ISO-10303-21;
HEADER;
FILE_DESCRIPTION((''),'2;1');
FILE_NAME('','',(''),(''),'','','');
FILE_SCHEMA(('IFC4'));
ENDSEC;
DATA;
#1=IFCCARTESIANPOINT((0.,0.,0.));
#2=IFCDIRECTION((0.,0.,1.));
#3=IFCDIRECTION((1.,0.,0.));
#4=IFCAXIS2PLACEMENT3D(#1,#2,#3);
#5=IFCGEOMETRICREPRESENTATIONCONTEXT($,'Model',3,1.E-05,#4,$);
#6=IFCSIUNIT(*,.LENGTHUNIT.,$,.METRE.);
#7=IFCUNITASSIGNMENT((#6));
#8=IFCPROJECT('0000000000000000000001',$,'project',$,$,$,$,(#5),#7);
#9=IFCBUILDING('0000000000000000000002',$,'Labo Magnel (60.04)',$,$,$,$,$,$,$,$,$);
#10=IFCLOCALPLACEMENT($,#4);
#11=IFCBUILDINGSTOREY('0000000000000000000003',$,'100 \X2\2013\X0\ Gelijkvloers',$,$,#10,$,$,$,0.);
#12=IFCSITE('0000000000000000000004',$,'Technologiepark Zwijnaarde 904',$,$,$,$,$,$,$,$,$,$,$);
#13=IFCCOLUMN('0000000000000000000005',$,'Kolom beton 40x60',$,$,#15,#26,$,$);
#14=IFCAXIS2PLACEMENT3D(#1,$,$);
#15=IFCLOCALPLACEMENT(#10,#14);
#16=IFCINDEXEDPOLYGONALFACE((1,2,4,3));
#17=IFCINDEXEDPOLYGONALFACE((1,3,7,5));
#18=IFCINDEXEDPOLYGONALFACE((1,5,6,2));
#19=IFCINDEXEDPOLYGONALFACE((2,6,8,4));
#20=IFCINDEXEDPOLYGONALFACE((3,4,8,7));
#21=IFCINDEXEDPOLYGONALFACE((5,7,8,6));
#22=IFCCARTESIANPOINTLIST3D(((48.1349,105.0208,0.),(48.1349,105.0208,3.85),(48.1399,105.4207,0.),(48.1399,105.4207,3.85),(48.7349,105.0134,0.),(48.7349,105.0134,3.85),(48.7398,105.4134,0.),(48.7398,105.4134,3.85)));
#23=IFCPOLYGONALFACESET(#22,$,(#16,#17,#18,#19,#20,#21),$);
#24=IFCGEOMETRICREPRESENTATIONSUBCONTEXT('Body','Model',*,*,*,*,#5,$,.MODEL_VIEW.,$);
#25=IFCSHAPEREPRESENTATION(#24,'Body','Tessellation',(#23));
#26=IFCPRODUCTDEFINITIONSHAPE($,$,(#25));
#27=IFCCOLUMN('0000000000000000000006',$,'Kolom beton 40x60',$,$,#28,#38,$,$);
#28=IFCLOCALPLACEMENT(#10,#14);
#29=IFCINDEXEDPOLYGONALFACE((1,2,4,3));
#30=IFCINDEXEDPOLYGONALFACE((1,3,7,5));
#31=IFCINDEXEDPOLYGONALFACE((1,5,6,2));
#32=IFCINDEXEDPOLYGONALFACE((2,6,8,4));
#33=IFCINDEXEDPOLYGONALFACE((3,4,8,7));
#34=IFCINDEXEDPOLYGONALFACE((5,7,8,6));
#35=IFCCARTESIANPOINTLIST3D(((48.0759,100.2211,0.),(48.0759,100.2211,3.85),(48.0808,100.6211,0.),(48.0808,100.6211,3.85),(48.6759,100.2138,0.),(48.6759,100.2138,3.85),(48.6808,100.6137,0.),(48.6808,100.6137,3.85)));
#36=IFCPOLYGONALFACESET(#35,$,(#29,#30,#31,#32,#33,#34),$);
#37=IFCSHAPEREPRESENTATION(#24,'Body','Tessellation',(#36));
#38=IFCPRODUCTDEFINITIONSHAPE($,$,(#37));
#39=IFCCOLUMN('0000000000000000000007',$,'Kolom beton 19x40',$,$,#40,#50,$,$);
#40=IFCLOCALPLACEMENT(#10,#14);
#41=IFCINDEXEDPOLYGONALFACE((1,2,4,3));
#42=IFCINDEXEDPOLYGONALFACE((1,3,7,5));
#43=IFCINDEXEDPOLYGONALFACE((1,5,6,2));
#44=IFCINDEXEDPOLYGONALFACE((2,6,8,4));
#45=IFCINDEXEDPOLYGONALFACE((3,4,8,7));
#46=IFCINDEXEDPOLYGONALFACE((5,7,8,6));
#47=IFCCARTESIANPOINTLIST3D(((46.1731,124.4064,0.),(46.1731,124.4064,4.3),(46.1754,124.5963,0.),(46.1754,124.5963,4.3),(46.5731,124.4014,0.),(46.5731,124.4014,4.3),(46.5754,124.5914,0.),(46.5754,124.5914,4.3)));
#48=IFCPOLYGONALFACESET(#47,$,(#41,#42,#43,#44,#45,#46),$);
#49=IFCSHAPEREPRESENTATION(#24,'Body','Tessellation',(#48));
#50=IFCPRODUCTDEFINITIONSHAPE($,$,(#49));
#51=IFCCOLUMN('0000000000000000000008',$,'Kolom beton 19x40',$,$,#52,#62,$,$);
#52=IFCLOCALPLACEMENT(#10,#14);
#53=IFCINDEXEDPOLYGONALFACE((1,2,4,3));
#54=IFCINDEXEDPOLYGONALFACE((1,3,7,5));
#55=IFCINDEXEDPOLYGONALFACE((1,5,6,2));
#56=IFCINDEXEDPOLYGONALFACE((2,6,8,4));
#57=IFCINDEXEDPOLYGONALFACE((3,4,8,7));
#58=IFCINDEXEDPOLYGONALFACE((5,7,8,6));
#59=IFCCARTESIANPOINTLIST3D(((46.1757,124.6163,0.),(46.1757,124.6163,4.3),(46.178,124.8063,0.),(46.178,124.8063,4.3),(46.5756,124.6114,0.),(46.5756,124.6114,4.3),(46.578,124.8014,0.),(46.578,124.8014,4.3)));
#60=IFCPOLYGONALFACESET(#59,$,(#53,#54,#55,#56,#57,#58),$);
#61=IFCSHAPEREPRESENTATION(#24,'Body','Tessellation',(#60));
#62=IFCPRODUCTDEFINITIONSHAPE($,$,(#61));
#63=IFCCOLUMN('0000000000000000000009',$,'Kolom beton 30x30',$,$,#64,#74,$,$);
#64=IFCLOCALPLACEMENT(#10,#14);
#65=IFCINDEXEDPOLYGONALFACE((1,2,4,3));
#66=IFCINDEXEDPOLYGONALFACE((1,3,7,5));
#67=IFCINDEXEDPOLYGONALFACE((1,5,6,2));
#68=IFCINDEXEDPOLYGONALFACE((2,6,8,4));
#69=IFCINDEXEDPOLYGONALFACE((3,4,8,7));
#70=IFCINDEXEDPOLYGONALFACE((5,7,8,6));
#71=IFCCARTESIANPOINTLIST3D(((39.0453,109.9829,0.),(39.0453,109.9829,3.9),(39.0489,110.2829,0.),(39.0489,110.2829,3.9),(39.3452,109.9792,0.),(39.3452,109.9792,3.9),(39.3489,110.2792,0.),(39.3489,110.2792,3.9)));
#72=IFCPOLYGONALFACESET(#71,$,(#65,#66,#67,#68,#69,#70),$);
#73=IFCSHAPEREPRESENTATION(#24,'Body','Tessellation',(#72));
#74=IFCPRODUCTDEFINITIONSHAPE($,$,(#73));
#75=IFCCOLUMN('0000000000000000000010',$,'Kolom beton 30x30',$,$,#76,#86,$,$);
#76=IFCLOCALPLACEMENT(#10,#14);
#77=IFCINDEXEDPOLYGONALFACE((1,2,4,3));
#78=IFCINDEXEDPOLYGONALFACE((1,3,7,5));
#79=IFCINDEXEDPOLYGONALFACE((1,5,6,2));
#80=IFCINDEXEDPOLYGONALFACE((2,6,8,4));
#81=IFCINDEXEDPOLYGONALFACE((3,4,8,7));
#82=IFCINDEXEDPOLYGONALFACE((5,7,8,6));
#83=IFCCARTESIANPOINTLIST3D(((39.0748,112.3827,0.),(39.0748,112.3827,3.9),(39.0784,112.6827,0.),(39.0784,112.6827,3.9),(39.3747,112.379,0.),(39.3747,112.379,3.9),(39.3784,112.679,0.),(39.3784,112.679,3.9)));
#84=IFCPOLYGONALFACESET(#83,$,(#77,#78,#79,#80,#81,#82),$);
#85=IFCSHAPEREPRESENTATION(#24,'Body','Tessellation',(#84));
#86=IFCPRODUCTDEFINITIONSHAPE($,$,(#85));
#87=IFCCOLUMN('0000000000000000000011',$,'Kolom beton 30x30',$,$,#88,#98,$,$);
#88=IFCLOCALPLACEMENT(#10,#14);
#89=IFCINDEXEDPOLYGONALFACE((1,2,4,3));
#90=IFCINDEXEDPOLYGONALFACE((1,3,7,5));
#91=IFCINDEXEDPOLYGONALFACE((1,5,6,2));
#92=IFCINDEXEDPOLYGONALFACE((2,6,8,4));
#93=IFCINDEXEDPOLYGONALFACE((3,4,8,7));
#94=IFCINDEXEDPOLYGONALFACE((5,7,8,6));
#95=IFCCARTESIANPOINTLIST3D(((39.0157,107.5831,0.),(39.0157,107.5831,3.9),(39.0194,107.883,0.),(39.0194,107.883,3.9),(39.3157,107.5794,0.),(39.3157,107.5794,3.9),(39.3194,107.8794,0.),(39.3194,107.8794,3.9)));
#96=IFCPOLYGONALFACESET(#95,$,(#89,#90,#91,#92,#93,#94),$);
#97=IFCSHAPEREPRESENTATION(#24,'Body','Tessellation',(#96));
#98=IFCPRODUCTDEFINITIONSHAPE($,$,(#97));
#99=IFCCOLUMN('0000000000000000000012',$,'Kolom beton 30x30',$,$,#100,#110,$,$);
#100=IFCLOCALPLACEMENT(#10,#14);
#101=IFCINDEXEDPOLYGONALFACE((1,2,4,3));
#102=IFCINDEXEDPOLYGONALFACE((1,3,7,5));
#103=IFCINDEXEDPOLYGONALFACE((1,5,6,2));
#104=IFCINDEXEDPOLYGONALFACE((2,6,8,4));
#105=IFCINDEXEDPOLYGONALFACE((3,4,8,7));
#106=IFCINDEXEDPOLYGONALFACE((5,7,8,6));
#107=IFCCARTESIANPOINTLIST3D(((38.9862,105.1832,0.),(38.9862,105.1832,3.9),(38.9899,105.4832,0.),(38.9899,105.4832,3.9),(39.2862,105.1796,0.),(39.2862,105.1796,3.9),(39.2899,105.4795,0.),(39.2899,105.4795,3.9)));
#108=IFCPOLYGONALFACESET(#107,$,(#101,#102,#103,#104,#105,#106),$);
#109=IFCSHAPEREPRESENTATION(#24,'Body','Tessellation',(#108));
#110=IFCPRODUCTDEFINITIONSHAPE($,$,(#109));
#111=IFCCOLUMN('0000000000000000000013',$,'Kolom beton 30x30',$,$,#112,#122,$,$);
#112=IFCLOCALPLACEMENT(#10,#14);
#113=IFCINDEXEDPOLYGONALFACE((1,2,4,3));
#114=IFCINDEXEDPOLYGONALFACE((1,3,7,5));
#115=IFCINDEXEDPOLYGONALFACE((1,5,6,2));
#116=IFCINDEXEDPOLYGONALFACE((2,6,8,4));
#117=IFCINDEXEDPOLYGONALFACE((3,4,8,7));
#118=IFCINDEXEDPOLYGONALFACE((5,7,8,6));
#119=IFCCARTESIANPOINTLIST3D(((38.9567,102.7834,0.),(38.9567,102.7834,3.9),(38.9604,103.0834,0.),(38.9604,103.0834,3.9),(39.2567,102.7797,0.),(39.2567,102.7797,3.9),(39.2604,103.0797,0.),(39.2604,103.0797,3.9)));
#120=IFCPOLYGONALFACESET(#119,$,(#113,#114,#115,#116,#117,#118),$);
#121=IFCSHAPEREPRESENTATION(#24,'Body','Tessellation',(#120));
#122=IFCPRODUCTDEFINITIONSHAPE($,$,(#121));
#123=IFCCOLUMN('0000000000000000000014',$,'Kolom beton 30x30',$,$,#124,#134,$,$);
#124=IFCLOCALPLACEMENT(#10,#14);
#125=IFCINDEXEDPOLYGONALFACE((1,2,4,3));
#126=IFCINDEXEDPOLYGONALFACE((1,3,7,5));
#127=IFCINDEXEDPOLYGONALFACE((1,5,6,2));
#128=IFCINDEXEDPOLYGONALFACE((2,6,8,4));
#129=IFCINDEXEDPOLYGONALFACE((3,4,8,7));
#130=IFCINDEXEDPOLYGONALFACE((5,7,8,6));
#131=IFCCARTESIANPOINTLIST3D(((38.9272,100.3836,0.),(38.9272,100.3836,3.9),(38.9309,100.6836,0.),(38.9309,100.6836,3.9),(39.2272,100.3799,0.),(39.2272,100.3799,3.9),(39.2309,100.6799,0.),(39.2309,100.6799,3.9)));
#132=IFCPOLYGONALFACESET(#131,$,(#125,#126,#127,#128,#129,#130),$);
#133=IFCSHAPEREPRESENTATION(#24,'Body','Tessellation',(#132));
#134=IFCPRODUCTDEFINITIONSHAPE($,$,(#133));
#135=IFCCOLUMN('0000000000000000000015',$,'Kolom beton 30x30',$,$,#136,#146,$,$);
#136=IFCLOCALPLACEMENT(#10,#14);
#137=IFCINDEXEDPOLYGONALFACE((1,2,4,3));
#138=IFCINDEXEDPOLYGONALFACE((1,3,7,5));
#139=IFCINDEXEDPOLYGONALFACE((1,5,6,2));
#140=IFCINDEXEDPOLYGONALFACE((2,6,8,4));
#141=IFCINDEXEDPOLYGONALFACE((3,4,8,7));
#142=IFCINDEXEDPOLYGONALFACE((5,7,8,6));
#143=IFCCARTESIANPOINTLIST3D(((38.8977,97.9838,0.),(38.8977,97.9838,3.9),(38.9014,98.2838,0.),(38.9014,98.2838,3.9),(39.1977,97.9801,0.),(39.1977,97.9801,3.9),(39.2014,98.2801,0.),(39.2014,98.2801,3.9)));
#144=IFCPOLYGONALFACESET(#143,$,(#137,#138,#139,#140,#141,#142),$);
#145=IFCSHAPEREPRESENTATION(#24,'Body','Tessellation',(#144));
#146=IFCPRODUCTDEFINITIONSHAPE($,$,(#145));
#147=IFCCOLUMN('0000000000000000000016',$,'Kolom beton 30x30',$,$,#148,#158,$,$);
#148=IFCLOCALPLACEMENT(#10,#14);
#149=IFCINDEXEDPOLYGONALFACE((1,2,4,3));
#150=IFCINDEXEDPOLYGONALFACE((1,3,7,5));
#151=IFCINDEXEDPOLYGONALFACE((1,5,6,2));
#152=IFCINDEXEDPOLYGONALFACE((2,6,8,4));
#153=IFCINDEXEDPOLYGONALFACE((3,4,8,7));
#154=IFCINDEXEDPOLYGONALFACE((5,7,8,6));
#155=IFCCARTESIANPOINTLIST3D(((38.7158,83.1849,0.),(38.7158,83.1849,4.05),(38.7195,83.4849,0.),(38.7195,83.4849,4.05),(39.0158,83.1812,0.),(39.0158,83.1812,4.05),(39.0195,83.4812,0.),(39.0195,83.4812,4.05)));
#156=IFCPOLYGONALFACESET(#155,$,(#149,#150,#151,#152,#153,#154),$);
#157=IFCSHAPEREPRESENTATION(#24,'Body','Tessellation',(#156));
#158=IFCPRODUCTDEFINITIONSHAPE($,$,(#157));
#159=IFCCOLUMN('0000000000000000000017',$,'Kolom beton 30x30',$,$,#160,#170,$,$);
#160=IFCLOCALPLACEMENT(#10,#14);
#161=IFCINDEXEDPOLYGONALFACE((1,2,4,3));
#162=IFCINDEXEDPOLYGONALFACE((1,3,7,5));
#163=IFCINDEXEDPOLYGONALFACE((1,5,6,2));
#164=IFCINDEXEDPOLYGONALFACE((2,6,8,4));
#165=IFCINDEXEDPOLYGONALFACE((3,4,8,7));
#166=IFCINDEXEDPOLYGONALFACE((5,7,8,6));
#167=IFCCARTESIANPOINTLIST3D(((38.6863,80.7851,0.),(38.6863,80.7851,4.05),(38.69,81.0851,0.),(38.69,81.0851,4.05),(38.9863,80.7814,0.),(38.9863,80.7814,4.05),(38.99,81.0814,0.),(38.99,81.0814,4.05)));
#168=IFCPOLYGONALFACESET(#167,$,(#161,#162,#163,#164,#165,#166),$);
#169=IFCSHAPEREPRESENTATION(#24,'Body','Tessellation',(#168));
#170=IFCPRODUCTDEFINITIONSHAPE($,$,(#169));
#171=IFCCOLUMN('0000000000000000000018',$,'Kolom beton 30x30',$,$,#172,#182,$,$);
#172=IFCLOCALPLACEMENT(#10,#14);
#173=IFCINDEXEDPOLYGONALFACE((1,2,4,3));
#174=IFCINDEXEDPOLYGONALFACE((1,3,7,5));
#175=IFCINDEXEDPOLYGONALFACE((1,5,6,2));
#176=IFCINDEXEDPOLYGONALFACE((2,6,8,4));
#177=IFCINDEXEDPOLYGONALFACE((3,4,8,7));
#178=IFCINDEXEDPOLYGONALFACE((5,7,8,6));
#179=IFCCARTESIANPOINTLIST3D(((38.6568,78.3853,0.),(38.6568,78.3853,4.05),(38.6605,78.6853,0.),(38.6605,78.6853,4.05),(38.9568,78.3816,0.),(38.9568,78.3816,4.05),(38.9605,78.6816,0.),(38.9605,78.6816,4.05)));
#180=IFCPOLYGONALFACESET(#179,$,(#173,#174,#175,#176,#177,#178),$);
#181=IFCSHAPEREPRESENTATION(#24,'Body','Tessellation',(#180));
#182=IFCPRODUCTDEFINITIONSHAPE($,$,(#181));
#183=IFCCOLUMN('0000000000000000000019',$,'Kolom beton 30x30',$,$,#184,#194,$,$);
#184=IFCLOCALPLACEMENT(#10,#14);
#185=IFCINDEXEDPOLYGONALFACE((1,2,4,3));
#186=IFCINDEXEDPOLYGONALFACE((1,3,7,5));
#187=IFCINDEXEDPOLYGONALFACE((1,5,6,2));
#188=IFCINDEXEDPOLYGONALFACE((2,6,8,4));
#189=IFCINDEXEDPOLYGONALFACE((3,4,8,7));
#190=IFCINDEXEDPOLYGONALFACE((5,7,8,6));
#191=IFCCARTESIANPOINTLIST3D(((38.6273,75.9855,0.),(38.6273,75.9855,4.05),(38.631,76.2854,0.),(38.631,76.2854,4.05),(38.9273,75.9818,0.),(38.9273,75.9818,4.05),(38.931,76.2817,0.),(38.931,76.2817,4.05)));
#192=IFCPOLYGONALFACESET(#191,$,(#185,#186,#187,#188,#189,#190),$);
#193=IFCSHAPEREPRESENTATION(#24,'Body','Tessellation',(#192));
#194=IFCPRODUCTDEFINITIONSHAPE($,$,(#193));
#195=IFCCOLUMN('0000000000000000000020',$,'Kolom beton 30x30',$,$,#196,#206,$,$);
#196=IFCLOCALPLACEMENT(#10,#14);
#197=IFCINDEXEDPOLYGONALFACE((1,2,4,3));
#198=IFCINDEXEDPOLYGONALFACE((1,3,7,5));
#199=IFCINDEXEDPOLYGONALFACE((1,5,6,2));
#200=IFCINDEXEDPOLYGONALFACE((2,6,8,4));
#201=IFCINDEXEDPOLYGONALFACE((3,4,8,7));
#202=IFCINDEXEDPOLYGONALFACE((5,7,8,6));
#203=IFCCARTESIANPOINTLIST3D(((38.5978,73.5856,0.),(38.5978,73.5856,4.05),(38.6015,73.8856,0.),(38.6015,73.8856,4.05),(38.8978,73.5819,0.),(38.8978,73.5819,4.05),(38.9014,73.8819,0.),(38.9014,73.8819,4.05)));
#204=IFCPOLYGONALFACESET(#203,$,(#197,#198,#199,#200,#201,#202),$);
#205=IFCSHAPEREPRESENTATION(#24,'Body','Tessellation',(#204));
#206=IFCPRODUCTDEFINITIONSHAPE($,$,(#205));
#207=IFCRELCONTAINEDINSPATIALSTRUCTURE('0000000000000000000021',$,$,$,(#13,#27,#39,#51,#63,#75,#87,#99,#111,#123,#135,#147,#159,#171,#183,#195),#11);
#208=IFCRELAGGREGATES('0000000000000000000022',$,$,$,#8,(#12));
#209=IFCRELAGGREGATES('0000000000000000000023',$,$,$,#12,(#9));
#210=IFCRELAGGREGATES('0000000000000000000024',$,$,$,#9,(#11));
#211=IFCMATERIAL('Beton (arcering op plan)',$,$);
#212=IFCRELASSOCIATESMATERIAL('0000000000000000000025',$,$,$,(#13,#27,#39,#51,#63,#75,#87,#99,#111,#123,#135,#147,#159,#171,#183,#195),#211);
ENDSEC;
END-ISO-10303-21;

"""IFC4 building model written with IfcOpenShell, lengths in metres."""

from ifc_helpers import new_model, si_unit, origin, origin_with_axes, place, context, subcontext, project, spatial, polyline, outline, extrude, material, element, save


model = new_model("IFC4")

# Units and contexts
model_context = context("Model", 3, precision=1e-05, world=origin_with_axes())
body_context = subcontext(model_context, "Body", "Model", "MODEL_VIEW")
ifc_project = project(units=[si_unit("LENGTHUNIT", "METRE")], contexts=[model_context])

# Site, building, storey
site = spatial("IfcSite", under=ifc_project, Name="Technologiepark Zwijnaarde 904")
building = spatial("IfcBuilding", under=site, Name="Labo Magnel (60.04)")
storey_placement = place(None, origin_with_axes())
storey = spatial("IfcBuildingStorey", under=building, at=storey_placement, Name="100 – Gelijkvloers", Elevation=0.0)

# Columns
ifc_material = material(Name="Beton (arcering op plan)")
column_1_placement = place(storey_placement, origin_with_axes())
element("IfcColumn", 1, at=column_1_placement, inside=storey, material=ifc_material, Name="Kolom beton 40x60", context=body_context, shape_type="SweptSolid", body=[
    extrude(outline(polyline([(48.7398, 105.4134), (48.1399, 105.4207), (48.1349, 105.0208), (48.7349, 105.0134), (48.7398, 105.4134)])), origin(), (0.0, 0.0, 1.0), 3.85),
])
column_2_placement = place(storey_placement, origin_with_axes())
element("IfcColumn", 2, at=column_2_placement, inside=storey, material=ifc_material, Name="Kolom beton 40x60", context=body_context, shape_type="SweptSolid", body=[
    extrude(outline(polyline([(48.6808, 100.6137), (48.0808, 100.6211), (48.0759, 100.2211), (48.6759, 100.2138), (48.6808, 100.6137)])), origin(), (0.0, 0.0, 1.0), 3.85),
])
column_3_placement = place(storey_placement, origin_with_axes())
element("IfcColumn", 3, at=column_3_placement, inside=storey, material=ifc_material, Name="Kolom beton 19x40", context=body_context, shape_type="SweptSolid", body=[
    extrude(outline(polyline([(46.5754, 124.5914), (46.1754, 124.5963), (46.1731, 124.4064), (46.5731, 124.4014), (46.5754, 124.5914)])), origin(), (0.0, 0.0, 1.0), 4.3),
])
column_4_placement = place(storey_placement, origin_with_axes())
element("IfcColumn", 4, at=column_4_placement, inside=storey, material=ifc_material, Name="Kolom beton 19x40", context=body_context, shape_type="SweptSolid", body=[
    extrude(outline(polyline([(46.578, 124.8014), (46.178, 124.8063), (46.1757, 124.6163), (46.5756, 124.6114), (46.578, 124.8014)])), origin(), (0.0, 0.0, 1.0), 4.3),
])
column_5_placement = place(storey_placement, origin_with_axes())
element("IfcColumn", 5, at=column_5_placement, inside=storey, material=ifc_material, Name="Kolom beton 30x30", context=body_context, shape_type="SweptSolid", body=[
    extrude(outline(polyline([(39.3489, 110.2792), (39.0489, 110.2829), (39.0453, 109.9829), (39.3452, 109.9792), (39.3489, 110.2792)])), origin(), (0.0, 0.0, 1.0), 3.9),
])
column_6_placement = place(storey_placement, origin_with_axes())
element("IfcColumn", 6, at=column_6_placement, inside=storey, material=ifc_material, Name="Kolom beton 30x30", context=body_context, shape_type="SweptSolid", body=[
    extrude(outline(polyline([(39.3784, 112.679), (39.0784, 112.6827), (39.0748, 112.3827), (39.3747, 112.379), (39.3784, 112.679)])), origin(), (0.0, 0.0, 1.0), 3.9),
])
column_7_placement = place(storey_placement, origin_with_axes())
element("IfcColumn", 7, at=column_7_placement, inside=storey, material=ifc_material, Name="Kolom beton 30x30", context=body_context, shape_type="SweptSolid", body=[
    extrude(outline(polyline([(39.3194, 107.8794), (39.0194, 107.883), (39.0157, 107.5831), (39.3157, 107.5794), (39.3194, 107.8794)])), origin(), (0.0, 0.0, 1.0), 3.9),
])
column_8_placement = place(storey_placement, origin_with_axes())
element("IfcColumn", 8, at=column_8_placement, inside=storey, material=ifc_material, Name="Kolom beton 30x30", context=body_context, shape_type="SweptSolid", body=[
    extrude(outline(polyline([(39.2899, 105.4795), (38.9899, 105.4832), (38.9862, 105.1832), (39.2862, 105.1796), (39.2899, 105.4795)])), origin(), (0.0, 0.0, 1.0), 3.9),
])
column_9_placement = place(storey_placement, origin_with_axes())
element("IfcColumn", 9, at=column_9_placement, inside=storey, material=ifc_material, Name="Kolom beton 30x30", context=body_context, shape_type="SweptSolid", body=[
    extrude(outline(polyline([(39.2604, 103.0797), (38.9604, 103.0834), (38.9567, 102.7834), (39.2567, 102.7797), (39.2604, 103.0797)])), origin(), (0.0, 0.0, 1.0), 3.9),
])
column_10_placement = place(storey_placement, origin_with_axes())
element("IfcColumn", 10, at=column_10_placement, inside=storey, material=ifc_material, Name="Kolom beton 30x30", context=body_context, shape_type="SweptSolid", body=[
    extrude(outline(polyline([(39.2309, 100.6799), (38.9309, 100.6836), (38.9272, 100.3836), (39.2272, 100.3799), (39.2309, 100.6799)])), origin(), (0.0, 0.0, 1.0), 3.9),
])
column_11_placement = place(storey_placement, origin_with_axes())
element("IfcColumn", 11, at=column_11_placement, inside=storey, material=ifc_material, Name="Kolom beton 30x30", context=body_context, shape_type="SweptSolid", body=[
    extrude(outline(polyline([(39.2014, 98.2801), (38.9014, 98.2838), (38.8977, 97.9838), (39.1977, 97.9801), (39.2014, 98.2801)])), origin(), (0.0, 0.0, 1.0), 3.9),
])
column_12_placement = place(storey_placement, origin_with_axes())
element("IfcColumn", 12, at=column_12_placement, inside=storey, material=ifc_material, Name="Kolom beton 30x30", context=body_context, shape_type="SweptSolid", body=[
    extrude(outline(polyline([(39.0195, 83.4812), (38.7195, 83.4849), (38.7158, 83.1849), (39.0158, 83.1812), (39.0195, 83.4812)])), origin(), (0.0, 0.0, 1.0), 4.05),
])
column_13_placement = place(storey_placement, origin_with_axes())
element("IfcColumn", 13, at=column_13_placement, inside=storey, material=ifc_material, Name="Kolom beton 30x30", context=body_context, shape_type="SweptSolid", body=[
    extrude(outline(polyline([(38.6863, 80.7851), (38.69, 81.0851), (38.99, 81.0814), (38.9863, 80.7814), (38.6863, 80.7851)])), origin(), (0.0, 0.0, 1.0), 4.05),
])
column_14_placement = place(storey_placement, origin_with_axes())
element("IfcColumn", 14, at=column_14_placement, inside=storey, material=ifc_material, Name="Kolom beton 30x30", context=body_context, shape_type="SweptSolid", body=[
    extrude(outline(polyline([(38.9605, 78.6816), (38.6605, 78.6853), (38.6568, 78.3853), (38.9568, 78.3816), (38.9605, 78.6816)])), origin(), (0.0, 0.0, 1.0), 4.05),
])
column_15_placement = place(storey_placement, origin_with_axes())
element("IfcColumn", 15, at=column_15_placement, inside=storey, material=ifc_material, Name="Kolom beton 30x30", context=body_context, shape_type="SweptSolid", body=[
    extrude(outline(polyline([(38.931, 76.2817), (38.631, 76.2854), (38.6273, 75.9855), (38.9273, 75.9818), (38.931, 76.2817)])), origin(), (0.0, 0.0, 1.0), 4.05),
])
column_16_placement = place(storey_placement, origin_with_axes())
element("IfcColumn", 16, at=column_16_placement, inside=storey, material=ifc_material, Name="Kolom beton 30x30", context=body_context, shape_type="SweptSolid", body=[
    extrude(outline(polyline([(38.9014, 73.8819), (38.6015, 73.8856), (38.5978, 73.5856), (38.8978, 73.5819), (38.9014, 73.8819)])), origin(), (0.0, 0.0, 1.0), 4.05),
])

save(model, "model.ifc")
